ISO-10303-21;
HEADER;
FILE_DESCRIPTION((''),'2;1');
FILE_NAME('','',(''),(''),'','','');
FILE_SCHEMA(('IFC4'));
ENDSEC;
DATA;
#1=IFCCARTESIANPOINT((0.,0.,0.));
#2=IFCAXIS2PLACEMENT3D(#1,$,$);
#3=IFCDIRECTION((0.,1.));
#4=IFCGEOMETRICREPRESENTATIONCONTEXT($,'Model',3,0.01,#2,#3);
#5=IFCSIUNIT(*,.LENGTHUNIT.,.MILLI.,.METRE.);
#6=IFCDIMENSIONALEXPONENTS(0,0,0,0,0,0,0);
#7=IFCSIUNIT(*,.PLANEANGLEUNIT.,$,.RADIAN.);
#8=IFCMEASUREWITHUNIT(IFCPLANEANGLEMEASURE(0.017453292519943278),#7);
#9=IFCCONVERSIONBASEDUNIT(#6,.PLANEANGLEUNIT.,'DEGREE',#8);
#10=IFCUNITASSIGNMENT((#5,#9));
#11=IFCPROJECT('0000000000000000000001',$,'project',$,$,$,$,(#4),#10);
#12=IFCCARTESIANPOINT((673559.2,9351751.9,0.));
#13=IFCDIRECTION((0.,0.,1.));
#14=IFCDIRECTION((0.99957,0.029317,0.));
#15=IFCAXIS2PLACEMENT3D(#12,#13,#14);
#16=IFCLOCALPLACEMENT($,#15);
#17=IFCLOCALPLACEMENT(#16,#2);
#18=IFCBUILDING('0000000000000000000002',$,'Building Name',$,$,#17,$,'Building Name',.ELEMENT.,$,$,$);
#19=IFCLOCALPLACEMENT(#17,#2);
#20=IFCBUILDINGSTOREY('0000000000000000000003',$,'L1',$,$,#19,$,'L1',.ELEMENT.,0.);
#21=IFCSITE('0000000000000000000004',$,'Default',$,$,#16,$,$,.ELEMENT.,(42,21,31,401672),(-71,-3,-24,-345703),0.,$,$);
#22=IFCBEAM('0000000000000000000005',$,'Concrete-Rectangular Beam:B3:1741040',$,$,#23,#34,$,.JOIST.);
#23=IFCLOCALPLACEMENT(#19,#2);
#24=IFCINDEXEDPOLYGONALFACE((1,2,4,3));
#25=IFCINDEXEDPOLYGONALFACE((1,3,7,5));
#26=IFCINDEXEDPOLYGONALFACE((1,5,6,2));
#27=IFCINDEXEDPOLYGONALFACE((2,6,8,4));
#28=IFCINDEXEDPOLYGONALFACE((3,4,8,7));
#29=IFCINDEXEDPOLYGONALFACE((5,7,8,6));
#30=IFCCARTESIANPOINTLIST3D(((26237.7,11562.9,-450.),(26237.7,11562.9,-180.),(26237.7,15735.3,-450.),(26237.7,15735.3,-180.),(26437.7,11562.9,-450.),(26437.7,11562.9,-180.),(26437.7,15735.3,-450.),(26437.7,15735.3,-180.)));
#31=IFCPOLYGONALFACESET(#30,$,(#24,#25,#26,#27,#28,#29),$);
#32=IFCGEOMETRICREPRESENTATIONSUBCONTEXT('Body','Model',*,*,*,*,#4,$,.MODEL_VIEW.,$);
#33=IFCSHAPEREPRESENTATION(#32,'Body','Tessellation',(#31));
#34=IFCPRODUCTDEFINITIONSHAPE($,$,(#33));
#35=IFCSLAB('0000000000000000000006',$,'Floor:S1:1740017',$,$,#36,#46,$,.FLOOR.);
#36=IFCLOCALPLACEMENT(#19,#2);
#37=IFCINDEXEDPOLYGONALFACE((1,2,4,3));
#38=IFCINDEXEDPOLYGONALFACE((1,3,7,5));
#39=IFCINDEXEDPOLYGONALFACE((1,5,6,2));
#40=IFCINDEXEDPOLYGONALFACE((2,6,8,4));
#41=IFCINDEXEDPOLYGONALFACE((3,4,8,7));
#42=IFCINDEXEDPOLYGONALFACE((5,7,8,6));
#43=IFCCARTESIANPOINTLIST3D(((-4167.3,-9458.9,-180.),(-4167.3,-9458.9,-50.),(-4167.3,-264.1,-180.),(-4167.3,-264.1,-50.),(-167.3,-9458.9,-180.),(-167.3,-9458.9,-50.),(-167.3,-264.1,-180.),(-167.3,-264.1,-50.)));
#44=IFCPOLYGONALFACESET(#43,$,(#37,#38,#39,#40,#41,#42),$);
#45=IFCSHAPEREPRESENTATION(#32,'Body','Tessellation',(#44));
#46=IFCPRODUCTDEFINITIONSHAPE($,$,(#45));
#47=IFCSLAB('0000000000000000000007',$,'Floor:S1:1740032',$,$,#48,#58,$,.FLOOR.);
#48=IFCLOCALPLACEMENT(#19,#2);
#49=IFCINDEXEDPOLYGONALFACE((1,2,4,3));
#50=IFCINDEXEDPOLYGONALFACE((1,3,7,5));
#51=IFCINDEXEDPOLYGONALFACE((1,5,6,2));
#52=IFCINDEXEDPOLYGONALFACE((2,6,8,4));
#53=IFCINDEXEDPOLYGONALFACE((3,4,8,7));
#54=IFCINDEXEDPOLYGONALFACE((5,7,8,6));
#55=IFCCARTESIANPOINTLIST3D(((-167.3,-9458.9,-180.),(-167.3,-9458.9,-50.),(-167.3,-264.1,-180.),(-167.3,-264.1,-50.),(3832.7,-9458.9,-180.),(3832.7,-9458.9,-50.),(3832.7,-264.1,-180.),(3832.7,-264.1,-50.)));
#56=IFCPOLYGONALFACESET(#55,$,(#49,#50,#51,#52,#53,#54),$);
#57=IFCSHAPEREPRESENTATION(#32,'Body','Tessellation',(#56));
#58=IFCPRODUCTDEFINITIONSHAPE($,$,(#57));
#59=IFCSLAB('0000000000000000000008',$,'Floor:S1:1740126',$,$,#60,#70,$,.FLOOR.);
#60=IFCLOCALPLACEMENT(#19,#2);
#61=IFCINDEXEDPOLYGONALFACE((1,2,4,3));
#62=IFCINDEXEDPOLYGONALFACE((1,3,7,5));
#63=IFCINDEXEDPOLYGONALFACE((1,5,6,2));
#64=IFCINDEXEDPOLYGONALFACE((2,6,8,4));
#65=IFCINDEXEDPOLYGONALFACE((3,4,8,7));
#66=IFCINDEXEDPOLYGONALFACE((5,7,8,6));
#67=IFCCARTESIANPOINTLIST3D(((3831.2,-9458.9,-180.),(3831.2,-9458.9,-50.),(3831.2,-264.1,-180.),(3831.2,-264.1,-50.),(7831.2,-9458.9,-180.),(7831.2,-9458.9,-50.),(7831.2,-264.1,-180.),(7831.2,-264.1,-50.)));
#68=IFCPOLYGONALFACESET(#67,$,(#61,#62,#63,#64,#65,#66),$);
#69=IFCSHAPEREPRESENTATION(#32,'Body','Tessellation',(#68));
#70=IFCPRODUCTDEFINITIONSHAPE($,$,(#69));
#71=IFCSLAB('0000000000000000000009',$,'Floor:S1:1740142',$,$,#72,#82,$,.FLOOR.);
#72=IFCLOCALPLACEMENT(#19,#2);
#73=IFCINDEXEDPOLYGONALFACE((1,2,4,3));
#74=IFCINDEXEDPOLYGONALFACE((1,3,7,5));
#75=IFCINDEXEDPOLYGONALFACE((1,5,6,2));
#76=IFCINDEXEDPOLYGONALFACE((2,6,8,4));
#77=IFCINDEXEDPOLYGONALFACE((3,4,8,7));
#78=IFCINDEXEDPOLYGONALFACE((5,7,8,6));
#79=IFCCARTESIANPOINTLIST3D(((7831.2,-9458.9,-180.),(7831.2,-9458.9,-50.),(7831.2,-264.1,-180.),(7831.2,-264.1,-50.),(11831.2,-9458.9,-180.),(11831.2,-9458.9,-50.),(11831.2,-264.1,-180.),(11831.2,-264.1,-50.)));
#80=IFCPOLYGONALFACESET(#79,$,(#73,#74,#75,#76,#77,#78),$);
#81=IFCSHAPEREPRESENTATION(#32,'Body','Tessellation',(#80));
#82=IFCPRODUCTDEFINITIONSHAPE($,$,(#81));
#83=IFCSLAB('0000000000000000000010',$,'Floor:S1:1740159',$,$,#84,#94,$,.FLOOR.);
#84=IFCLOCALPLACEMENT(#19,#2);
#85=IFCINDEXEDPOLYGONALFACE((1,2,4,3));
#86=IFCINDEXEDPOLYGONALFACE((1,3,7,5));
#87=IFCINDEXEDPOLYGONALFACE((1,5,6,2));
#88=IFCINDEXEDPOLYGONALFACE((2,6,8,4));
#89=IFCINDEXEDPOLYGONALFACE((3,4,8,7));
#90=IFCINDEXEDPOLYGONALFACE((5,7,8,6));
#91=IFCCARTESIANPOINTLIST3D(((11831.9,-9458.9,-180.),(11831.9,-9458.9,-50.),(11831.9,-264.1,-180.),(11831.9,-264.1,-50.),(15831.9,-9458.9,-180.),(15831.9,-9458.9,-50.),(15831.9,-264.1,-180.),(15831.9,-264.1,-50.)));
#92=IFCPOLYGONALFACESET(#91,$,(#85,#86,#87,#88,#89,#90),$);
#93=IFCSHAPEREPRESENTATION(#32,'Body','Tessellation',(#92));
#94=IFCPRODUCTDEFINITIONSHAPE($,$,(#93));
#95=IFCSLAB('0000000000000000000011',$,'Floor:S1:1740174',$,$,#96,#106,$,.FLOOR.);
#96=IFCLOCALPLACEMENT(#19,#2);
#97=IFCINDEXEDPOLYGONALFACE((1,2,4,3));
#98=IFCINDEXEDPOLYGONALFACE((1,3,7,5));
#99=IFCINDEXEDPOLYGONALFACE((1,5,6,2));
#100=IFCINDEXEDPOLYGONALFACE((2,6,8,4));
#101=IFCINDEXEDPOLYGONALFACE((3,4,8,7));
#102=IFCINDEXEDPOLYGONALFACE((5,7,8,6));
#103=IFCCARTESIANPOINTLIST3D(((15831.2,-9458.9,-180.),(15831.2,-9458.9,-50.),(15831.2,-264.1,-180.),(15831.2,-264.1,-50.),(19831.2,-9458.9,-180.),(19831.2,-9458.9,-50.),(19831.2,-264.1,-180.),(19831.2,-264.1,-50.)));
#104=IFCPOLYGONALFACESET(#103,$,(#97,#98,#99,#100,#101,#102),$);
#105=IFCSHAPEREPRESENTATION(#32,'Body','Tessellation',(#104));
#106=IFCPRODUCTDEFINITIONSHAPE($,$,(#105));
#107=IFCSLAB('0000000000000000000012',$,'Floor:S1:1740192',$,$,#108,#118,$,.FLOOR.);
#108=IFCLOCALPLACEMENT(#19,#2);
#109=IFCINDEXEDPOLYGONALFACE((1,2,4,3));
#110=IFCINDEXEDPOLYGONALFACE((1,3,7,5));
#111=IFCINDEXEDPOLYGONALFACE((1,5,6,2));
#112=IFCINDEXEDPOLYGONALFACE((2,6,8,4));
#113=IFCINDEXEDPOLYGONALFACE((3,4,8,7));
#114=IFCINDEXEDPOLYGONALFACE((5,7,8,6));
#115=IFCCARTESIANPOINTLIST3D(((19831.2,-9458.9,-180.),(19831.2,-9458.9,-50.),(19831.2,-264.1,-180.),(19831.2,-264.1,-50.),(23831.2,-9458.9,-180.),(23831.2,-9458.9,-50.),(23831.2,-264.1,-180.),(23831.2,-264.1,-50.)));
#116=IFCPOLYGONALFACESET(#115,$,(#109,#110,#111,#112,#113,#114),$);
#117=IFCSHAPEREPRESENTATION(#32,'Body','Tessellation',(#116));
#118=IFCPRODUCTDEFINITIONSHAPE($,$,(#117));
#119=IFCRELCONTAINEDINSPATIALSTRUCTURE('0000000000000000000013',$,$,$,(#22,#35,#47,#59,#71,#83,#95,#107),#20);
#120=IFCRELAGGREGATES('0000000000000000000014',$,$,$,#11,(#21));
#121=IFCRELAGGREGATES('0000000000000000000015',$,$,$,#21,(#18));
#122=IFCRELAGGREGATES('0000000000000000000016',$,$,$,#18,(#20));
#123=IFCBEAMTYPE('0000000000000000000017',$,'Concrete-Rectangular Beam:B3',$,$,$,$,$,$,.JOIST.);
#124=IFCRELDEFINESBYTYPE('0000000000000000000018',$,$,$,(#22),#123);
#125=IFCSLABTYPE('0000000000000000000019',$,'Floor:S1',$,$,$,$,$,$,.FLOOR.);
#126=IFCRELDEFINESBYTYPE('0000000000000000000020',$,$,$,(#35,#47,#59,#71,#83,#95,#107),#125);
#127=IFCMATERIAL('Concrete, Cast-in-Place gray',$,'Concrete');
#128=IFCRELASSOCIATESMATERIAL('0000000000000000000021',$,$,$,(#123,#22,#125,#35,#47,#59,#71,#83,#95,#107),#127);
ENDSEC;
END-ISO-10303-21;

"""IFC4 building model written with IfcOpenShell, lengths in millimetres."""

from ifc_helpers import new_model, entity, si_unit, converted_unit, direction, frame, origin, place, context, subcontext, project, spatial, indexed_curve, outline, extrude, source, transform, mapped, material, type_object, type_shapes, element, save


model = new_model("IFC4")

# Units and contexts
model_context = context("Model", 3, precision=0.01, world=origin(), true_north=direction((0.0, 1.0)))
body_context = subcontext(model_context, "Body", "Model", "MODEL_VIEW")
ifc_project = project(units=[si_unit("LENGTHUNIT", "METRE", prefix="MILLI"), converted_unit("PLANEANGLEUNIT", "DEGREE", entity("IfcPlaneAngleMeasure", 0.017453292519943278), si_unit("PLANEANGLEUNIT", "RADIAN"), dimensions=[0, 0, 0, 0, 0, 0, 0])], contexts=[model_context])

# Site, building, storey
site_placement = place(None, frame((673559.2, 9351751.9, 0.0), z_axis=(0.0, 0.0, 1.0), x_axis=(0.99957, 0.029317, 0.0)))
site = spatial("IfcSite", under=ifc_project, at=site_placement, Name="Default", CompositionType="ELEMENT", RefLatitude=(42, 21, 31, 401672), RefLongitude=(-71, -3, -24, -345703), RefElevation=0.0)
building_placement = place(site_placement, origin())
building = spatial("IfcBuilding", under=site, at=building_placement, Name="Building Name", LongName="Building Name", CompositionType="ELEMENT")
storey_placement = place(building_placement, origin())
storey = spatial("IfcBuildingStorey", under=building, at=storey_placement, Name="L1", LongName="L1", CompositionType="ELEMENT", Elevation=0.0)

# Beam
ifc_material = material(Name="Concrete, Cast-in-Place gray", Category="Concrete")
beam_type_1 = type_object("IfcBeamType", Name="Concrete-Rectangular Beam:B3", PredefinedType="JOIST", material=ifc_material)
shared_shape_1 = source(origin(), body_context, "Body", "SweptSolid", [
    extrude(outline(indexed_curve([(-100.0, -135.0), (100.0, -135.0), (100.0, 135.0), (-100.0, 135.0), (-100.0, -135.0)], self_intersect=False)), frame((26337.7, 15735.3, -315.0), z_axis=(0.0, -1.0, 0.0), x_axis=(-1.0, 0.0, 0.0)), (0.0, 0.0, 1.0), 4172.4),
])
type_shapes(beam_type_1, [shared_shape_1])
beam_1_placement = place(storey_placement, origin())
element("IfcBeam", 1, at=beam_1_placement, inside=storey, type_object=beam_type_1, material=ifc_material, Name="Concrete-Rectangular Beam:B3:1741040", PredefinedType="JOIST", context=body_context, shape_type="MappedRepresentation", body=[
    mapped(shared_shape_1, transform((0.0, 0.0, 0.0), scale=1.0)),
])

# Slabs
slab_type_1 = type_object("IfcSlabType", Name="Floor:S1", PredefinedType="FLOOR", material=ifc_material)
slab_1_placement = place(storey_placement, origin())
element("IfcSlab", 2, at=slab_1_placement, inside=storey, type_object=slab_type_1, material=ifc_material, Name="Floor:S1:1740017", PredefinedType="FLOOR", context=body_context, shape_type="SweptSolid", body=[
    extrude(outline(indexed_curve([(-4597.4, -2000.0), (4597.4, -2000.0), (4597.4, 2000.0), (-4597.4, 2000.0), (-4597.4, -2000.0)], self_intersect=False)), frame((-2167.3, -4861.5, -50.0), z_axis=(0.0, 0.0, -1.0), x_axis=(0.0, 1.0, 0.0)), (0.0, 0.0, 1.0), 130.0),
])
slab_2_placement = place(storey_placement, origin())
element("IfcSlab", 3, at=slab_2_placement, inside=storey, type_object=slab_type_1, material=ifc_material, Name="Floor:S1:1740032", PredefinedType="FLOOR", context=body_context, shape_type="SweptSolid", body=[
    extrude(outline(indexed_curve([(-4597.4, -2000.0), (4597.4, -2000.0), (4597.4, 2000.0), (-4597.4, 2000.0), (-4597.4, -2000.0)], self_intersect=False)), frame((1832.7, -4861.5, -50.0), z_axis=(0.0, 0.0, -1.0), x_axis=(0.0, 1.0, 0.0)), (0.0, 0.0, 1.0), 130.0),
])
slab_3_placement = place(storey_placement, origin())
element("IfcSlab", 4, at=slab_3_placement, inside=storey, type_object=slab_type_1, material=ifc_material, Name="Floor:S1:1740126", PredefinedType="FLOOR", context=body_context, shape_type="SweptSolid", body=[
    extrude(outline(indexed_curve([(-4597.4, -2000.0), (4597.4, -2000.0), (4597.4, 2000.0), (-4597.4, 2000.0), (-4597.4, -2000.0)], self_intersect=False)), frame((5831.2, -4861.5, -50.0), z_axis=(0.0, 0.0, -1.0), x_axis=(0.0, 1.0, 0.0)), (0.0, 0.0, 1.0), 130.0),
])
slab_4_placement = place(storey_placement, origin())
element("IfcSlab", 5, at=slab_4_placement, inside=storey, type_object=slab_type_1, material=ifc_material, Name="Floor:S1:1740142", PredefinedType="FLOOR", context=body_context, shape_type="SweptSolid", body=[
    extrude(outline(indexed_curve([(-4597.4, -2000.0), (4597.4, -2000.0), (4597.4, 2000.0), (-4597.4, 2000.0), (-4597.4, -2000.0)], self_intersect=False)), frame((9831.2, -4861.5, -50.0), z_axis=(0.0, 0.0, -1.0), x_axis=(0.0, 1.0, 0.0)), (0.0, 0.0, 1.0), 130.0),
])
slab_5_placement = place(storey_placement, origin())
element("IfcSlab", 6, at=slab_5_placement, inside=storey, type_object=slab_type_1, material=ifc_material, Name="Floor:S1:1740159", PredefinedType="FLOOR", context=body_context, shape_type="SweptSolid", body=[
    extrude(outline(indexed_curve([(-4597.4, -2000.0), (4597.4, -2000.0), (4597.4, 2000.0), (-4597.4, 2000.0), (-4597.4, -2000.0)], self_intersect=False)), frame((13831.9, -4861.5, -50.0), z_axis=(0.0, 0.0, -1.0), x_axis=(0.0, 1.0, 0.0)), (0.0, 0.0, 1.0), 130.0),
])
slab_6_placement = place(storey_placement, origin())
element("IfcSlab", 7, at=slab_6_placement, inside=storey, type_object=slab_type_1, material=ifc_material, Name="Floor:S1:1740174", PredefinedType="FLOOR", context=body_context, shape_type="SweptSolid", body=[
    extrude(outline(indexed_curve([(-4597.4, -2000.0), (4597.4, -2000.0), (4597.4, 2000.0), (-4597.4, 2000.0), (-4597.4, -2000.0)], self_intersect=False)), frame((17831.2, -4861.5, -50.0), z_axis=(0.0, 0.0, -1.0), x_axis=(0.0, 1.0, 0.0)), (0.0, 0.0, 1.0), 130.0),
])
slab_7_placement = place(storey_placement, origin())
element("IfcSlab", 8, at=slab_7_placement, inside=storey, type_object=slab_type_1, material=ifc_material, Name="Floor:S1:1740192", PredefinedType="FLOOR", context=body_context, shape_type="SweptSolid", body=[
    extrude(outline(indexed_curve([(-4597.4, -2000.0), (4597.4, -2000.0), (4597.4, 2000.0), (-4597.4, 2000.0), (-4597.4, -2000.0)], self_intersect=False)), frame((21831.2, -4861.5, -50.0), z_axis=(0.0, 0.0, -1.0), x_axis=(0.0, 1.0, 0.0)), (0.0, 0.0, 1.0), 130.0),
])

save(model, "model.ifc")
